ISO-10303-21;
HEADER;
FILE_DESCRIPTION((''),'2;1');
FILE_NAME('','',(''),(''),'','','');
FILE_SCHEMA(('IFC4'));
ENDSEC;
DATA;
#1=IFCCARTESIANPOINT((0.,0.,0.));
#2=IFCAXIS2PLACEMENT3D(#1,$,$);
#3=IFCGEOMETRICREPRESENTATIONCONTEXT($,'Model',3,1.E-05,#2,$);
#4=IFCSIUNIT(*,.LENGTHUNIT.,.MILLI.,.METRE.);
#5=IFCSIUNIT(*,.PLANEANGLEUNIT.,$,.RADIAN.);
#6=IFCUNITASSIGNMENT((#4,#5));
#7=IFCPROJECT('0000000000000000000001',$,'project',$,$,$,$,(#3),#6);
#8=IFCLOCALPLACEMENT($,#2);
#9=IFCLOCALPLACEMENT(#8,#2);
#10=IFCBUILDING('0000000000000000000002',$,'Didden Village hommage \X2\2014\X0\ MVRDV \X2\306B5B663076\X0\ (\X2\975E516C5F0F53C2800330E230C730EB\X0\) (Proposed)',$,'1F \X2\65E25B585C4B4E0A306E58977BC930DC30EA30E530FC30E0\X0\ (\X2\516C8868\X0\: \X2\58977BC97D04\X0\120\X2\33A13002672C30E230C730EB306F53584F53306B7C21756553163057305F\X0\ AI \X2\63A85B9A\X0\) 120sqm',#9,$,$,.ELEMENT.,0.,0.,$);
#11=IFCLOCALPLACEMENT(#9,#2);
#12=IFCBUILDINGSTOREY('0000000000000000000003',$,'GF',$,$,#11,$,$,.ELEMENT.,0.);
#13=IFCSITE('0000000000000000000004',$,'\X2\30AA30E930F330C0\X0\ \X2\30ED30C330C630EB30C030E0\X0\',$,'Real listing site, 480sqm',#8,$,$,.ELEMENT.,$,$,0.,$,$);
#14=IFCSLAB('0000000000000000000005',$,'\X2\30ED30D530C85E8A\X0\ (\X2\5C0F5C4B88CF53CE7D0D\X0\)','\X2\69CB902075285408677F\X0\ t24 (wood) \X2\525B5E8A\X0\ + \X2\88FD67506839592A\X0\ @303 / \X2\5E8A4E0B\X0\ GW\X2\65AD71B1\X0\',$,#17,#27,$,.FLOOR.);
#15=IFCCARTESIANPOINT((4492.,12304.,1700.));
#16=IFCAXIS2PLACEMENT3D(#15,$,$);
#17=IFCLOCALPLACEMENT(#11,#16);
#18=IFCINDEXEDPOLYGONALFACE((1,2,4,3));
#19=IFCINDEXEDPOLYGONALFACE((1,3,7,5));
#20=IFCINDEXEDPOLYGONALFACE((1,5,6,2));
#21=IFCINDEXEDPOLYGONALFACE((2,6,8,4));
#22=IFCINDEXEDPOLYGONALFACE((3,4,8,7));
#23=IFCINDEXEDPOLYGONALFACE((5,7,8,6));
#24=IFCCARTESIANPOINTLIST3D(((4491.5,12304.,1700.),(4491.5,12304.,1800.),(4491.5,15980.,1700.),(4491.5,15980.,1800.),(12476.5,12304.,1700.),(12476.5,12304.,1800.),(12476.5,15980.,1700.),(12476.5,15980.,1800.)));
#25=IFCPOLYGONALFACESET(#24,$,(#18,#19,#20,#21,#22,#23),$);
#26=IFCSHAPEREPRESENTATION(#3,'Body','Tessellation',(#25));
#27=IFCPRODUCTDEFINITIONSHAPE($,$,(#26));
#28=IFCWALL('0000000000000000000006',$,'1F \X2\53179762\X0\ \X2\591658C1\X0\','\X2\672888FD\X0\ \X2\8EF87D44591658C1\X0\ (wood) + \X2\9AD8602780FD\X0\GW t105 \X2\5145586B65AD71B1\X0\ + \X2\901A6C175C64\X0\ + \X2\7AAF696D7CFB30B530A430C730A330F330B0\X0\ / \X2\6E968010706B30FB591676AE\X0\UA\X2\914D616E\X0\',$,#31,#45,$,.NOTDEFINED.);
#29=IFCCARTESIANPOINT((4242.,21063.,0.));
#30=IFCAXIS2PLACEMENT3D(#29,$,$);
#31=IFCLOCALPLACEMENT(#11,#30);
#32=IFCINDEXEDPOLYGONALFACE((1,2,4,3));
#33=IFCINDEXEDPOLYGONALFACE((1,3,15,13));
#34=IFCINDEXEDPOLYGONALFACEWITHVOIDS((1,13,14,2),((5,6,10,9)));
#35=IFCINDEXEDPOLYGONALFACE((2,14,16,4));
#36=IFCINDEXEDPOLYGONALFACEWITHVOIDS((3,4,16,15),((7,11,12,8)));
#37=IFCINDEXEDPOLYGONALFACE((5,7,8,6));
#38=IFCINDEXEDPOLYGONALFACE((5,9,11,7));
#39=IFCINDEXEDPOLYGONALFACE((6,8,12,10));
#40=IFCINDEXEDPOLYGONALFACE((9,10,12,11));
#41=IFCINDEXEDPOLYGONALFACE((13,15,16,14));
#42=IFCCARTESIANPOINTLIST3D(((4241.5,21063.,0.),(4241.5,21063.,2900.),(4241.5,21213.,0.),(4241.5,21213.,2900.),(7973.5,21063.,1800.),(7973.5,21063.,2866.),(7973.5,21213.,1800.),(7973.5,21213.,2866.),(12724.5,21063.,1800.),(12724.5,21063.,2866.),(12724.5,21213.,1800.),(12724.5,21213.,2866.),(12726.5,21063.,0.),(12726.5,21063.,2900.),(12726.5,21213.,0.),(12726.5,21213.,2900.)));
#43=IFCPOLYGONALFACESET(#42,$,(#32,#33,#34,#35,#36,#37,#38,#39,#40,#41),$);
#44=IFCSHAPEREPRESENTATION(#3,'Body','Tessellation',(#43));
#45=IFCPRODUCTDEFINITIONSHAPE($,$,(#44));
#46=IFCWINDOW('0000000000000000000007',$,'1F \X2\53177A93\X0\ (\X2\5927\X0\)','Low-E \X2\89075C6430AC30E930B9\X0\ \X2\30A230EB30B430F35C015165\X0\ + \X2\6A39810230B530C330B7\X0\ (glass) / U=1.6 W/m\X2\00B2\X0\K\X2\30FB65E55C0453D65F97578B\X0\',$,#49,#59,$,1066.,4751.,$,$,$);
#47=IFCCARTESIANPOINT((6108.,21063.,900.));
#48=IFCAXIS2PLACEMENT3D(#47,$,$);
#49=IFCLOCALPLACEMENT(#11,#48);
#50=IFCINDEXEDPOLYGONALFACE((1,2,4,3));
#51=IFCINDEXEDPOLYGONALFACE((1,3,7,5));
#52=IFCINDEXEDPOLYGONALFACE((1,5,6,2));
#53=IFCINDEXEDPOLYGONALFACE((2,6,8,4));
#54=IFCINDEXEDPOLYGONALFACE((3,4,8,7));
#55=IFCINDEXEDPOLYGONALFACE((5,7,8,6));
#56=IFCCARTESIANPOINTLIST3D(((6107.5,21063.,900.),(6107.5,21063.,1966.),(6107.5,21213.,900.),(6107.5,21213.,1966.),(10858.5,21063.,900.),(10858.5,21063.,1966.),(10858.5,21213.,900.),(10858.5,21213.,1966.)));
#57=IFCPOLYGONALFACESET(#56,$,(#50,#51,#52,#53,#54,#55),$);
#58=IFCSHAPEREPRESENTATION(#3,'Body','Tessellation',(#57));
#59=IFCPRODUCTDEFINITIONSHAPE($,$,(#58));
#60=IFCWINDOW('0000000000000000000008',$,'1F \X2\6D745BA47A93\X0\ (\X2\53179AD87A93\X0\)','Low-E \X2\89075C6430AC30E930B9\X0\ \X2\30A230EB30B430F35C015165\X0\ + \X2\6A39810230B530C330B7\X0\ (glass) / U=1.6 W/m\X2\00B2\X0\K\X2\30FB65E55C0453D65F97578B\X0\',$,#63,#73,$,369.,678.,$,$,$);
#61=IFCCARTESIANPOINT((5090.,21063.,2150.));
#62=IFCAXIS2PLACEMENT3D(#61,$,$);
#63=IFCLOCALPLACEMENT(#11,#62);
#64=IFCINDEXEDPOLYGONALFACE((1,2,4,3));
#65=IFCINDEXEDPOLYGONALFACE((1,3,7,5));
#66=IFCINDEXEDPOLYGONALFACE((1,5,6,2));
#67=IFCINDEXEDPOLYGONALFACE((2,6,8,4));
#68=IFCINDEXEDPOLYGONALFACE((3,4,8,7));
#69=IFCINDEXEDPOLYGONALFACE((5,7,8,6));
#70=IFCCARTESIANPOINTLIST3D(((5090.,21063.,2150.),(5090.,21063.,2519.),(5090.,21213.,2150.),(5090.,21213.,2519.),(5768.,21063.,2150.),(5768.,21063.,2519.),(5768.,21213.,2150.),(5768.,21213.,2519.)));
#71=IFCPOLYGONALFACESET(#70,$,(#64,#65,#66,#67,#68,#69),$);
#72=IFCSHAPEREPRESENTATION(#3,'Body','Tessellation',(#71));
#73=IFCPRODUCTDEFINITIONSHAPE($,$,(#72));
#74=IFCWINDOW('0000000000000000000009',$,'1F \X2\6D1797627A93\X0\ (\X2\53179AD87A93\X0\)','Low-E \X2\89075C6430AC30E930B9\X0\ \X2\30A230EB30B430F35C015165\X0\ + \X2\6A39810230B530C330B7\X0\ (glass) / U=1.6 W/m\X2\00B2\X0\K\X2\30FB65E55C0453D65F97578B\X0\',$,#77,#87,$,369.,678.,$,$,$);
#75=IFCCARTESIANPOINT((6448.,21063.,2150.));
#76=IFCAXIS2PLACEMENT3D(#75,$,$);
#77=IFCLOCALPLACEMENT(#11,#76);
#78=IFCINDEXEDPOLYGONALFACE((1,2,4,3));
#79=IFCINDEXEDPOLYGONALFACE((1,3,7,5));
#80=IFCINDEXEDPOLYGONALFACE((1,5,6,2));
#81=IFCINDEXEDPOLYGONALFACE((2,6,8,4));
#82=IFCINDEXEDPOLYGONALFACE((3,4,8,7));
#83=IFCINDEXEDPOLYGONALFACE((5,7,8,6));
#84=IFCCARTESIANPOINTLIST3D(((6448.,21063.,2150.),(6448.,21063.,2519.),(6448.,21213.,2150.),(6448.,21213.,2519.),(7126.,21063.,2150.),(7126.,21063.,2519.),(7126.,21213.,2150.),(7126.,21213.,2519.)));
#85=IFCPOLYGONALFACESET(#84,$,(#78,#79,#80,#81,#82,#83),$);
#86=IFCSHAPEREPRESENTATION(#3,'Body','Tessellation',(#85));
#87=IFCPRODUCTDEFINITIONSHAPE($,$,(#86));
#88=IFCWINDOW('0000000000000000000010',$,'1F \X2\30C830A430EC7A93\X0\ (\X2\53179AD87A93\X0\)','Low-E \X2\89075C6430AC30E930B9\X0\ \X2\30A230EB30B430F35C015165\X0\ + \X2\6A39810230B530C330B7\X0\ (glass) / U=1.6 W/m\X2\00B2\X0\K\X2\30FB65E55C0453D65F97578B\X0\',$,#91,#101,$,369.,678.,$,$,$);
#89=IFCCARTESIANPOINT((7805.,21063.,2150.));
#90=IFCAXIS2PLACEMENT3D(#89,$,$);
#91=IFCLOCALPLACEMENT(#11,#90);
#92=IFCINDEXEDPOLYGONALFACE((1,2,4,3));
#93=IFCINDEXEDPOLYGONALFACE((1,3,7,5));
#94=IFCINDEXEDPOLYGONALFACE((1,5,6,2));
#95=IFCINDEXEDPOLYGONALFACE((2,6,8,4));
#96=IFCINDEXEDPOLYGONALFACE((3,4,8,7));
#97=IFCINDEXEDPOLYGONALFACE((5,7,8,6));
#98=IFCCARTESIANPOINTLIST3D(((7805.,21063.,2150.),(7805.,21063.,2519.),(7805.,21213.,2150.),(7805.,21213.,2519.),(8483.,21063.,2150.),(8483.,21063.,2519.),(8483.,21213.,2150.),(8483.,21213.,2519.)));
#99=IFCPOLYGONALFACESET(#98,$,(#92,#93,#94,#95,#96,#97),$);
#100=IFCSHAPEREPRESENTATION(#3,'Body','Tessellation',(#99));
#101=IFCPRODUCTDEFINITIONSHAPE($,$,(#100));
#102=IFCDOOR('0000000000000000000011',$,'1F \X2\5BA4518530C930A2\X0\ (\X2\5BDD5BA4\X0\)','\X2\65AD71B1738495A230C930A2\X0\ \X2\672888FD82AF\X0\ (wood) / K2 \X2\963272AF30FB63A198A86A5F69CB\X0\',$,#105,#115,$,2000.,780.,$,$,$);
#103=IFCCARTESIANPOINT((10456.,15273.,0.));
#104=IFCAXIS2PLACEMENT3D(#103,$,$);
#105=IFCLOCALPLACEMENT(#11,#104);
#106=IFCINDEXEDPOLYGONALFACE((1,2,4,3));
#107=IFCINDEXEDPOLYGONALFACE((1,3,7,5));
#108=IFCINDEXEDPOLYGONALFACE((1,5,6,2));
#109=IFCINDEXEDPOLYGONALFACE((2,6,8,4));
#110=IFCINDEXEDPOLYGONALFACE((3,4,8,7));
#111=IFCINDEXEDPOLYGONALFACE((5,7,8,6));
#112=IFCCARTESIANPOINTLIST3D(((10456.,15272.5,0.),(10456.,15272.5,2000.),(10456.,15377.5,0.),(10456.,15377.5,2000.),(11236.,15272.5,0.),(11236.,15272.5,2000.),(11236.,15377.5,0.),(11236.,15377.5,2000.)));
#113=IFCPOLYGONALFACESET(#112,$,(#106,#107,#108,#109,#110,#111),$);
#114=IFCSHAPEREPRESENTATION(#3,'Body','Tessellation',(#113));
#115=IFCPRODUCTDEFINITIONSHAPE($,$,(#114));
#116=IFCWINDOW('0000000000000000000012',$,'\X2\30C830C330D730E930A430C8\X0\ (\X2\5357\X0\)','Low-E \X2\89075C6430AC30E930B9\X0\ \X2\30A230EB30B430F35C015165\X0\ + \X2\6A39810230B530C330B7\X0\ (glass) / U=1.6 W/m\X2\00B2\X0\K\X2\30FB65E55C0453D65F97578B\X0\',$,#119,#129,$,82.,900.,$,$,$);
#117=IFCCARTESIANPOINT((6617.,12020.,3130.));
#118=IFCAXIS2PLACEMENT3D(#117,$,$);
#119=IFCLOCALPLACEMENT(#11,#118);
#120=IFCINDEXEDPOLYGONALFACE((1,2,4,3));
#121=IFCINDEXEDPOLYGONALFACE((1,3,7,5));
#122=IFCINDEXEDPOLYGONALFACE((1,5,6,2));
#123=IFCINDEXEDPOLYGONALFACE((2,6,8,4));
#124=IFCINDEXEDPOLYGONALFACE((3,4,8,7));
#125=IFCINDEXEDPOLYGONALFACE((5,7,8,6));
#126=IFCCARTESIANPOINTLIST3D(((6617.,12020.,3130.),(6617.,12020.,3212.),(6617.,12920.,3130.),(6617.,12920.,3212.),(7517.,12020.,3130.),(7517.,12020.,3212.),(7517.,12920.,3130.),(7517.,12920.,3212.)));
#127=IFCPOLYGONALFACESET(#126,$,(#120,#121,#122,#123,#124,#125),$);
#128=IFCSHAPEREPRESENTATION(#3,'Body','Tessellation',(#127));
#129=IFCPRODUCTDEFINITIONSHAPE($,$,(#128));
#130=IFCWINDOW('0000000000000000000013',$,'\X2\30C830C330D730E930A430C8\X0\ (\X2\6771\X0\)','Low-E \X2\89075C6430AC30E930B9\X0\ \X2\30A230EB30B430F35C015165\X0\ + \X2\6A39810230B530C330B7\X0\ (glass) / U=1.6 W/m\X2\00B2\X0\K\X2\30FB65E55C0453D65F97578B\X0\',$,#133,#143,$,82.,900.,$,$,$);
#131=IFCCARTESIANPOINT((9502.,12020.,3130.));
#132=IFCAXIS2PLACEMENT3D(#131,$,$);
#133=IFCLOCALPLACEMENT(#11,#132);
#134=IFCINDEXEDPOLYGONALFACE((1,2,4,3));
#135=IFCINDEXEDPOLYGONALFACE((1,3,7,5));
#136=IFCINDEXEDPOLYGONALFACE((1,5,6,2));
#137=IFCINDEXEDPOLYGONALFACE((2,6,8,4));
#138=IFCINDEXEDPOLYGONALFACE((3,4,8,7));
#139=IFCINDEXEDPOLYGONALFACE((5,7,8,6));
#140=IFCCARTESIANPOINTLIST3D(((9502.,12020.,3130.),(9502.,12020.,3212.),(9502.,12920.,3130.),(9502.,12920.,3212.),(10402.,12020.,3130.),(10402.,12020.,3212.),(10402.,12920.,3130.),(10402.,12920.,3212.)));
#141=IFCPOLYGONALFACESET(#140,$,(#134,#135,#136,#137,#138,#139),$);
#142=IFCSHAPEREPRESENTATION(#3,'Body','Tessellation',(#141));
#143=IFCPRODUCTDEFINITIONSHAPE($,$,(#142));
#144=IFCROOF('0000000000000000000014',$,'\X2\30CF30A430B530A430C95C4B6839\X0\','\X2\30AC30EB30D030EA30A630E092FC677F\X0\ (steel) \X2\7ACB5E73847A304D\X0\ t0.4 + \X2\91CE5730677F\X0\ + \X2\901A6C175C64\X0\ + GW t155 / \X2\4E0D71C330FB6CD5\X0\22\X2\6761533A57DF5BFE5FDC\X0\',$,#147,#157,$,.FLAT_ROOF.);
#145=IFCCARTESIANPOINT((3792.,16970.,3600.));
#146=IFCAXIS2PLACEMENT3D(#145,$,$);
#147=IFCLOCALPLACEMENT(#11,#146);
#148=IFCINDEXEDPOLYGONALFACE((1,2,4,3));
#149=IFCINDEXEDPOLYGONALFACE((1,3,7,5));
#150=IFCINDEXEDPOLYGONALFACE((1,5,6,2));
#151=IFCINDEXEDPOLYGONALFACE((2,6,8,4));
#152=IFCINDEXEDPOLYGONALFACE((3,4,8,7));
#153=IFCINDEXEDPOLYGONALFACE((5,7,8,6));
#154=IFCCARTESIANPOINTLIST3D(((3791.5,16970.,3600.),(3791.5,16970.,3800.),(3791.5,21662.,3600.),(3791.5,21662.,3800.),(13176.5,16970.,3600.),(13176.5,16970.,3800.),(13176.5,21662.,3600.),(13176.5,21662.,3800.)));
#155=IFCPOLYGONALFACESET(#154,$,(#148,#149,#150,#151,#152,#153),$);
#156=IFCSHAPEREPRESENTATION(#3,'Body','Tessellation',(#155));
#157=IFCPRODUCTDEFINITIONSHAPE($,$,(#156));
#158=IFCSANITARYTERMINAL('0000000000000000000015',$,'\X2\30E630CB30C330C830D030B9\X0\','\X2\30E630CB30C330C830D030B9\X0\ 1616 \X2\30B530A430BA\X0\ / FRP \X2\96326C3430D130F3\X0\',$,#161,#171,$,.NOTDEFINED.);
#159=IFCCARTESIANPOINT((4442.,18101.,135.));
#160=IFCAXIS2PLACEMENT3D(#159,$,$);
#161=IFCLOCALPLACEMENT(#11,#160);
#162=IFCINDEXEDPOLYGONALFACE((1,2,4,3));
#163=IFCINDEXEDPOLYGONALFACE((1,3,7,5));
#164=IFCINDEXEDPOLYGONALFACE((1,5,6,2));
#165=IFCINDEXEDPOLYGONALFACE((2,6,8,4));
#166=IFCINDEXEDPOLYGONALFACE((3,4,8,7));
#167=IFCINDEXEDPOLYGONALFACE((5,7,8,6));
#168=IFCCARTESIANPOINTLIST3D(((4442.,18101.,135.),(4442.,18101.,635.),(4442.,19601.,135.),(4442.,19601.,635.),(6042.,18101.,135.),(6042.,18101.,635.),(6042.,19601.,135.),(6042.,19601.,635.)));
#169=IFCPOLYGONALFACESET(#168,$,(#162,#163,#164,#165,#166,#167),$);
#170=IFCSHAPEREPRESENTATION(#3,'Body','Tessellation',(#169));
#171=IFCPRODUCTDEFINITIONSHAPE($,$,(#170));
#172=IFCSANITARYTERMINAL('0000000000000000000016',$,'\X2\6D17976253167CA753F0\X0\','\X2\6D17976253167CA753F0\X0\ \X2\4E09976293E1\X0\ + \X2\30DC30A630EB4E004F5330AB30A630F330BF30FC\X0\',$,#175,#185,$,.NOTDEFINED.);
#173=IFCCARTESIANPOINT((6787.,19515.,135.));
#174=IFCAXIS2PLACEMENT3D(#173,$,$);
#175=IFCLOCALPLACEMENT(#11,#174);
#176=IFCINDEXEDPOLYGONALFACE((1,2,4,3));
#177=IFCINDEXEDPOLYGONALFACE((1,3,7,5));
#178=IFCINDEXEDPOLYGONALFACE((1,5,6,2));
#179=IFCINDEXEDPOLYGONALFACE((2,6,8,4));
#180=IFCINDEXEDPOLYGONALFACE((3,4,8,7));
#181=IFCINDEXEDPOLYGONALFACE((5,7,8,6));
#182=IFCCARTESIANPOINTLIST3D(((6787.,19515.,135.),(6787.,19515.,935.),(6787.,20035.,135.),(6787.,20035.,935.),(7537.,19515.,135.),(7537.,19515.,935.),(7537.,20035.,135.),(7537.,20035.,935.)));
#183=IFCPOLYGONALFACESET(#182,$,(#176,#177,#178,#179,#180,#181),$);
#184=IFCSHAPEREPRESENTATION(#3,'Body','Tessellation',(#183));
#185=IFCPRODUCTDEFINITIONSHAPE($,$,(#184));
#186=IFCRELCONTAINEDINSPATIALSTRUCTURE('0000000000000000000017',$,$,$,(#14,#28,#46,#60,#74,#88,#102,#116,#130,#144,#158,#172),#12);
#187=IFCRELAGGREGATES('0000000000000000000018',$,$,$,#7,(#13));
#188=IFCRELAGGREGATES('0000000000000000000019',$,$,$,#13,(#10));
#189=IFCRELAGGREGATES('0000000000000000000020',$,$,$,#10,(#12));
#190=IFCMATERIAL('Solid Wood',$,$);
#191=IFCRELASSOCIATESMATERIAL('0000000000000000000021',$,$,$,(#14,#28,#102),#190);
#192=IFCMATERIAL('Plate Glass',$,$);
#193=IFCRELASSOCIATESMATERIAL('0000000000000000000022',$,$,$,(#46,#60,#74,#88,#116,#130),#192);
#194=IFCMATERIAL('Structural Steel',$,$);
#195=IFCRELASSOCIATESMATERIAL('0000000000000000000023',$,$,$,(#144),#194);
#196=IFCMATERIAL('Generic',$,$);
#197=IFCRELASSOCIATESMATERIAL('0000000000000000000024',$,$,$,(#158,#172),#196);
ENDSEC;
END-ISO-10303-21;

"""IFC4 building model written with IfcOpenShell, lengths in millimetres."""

from ifc_helpers import new_model, si_unit, frame, frame_2d, origin, place, context, project, spatial, rectangle, extrude, material, element, fill, save


model = new_model("IFC4")

# Units and contexts
model_context = context("Model", 3, precision=1e-05, world=origin())
ifc_project = project(units=[si_unit("LENGTHUNIT", "METRE", prefix="MILLI"), si_unit("PLANEANGLEUNIT", "RADIAN")], contexts=[model_context])

# Site, building, storey
site_placement = place(None, origin())
site = spatial("IfcSite", under=ifc_project, at=site_placement, Name="オランダ ロッテルダム", ObjectType="Real listing site, 480sqm", CompositionType="ELEMENT", RefElevation=0.0)
building_placement = place(site_placement, origin())
building = spatial("IfcBuilding", under=site, at=building_placement, Name="Didden Village hommage — MVRDV に学ぶ (非公式参考モデル) (Proposed)", ObjectType="1F 既存屋上の増築ボリューム (公表: 増築約120㎡。本モデルは単体に簡略化した AI 推定) 120sqm", CompositionType="ELEMENT", ElevationOfRefHeight=0.0, ElevationOfTerrain=0.0)
storey_placement = place(building_placement, origin())
storey = spatial("IfcBuildingStorey", under=building, at=storey_placement, Name="GF", CompositionType="ELEMENT", Elevation=0.0)

# Slab
ifc_material_1 = material(Name="Solid Wood")
slab_placement = place(storey_placement, frame((4492.0, 12304.0, 1700.0)))
element("IfcSlab", 1, at=slab_placement, inside=storey, material=ifc_material_1, Name="ロフト床 (小屋裏収納)", Description="構造用合板 t24 (wood) 剛床 + 製材根太 @303 / 床下 GW断熱", PredefinedType="FLOOR", context=model_context, shape_type="SweptSolid", body=[
    extrude(rectangle(XDim=7985.0, YDim=3676.0, at=frame_2d((3992.0, 1838.0))), frame((4492.0, 12304.0, 1700.0)), (0.0, 0.0, 1.0), 100.0),
])

# Wall, openings, windows
wall_1_placement = place(storey_placement, frame((4242.0, 21063.0, 0.0)))
wall_1 = element("IfcWall", 2, at=wall_1_placement, inside=storey, material=ifc_material_1, Name="1F 北面 外壁", Description="木製 軸組外壁 (wood) + 高性能GW t105 充填断熱 + 通気層 + 窯業系サイディング / 準耐火・外皮UA配慮", PredefinedType="NOTDEFINED", context=model_context, shape_type="SweptSolid", body=[
    extrude(rectangle(XDim=8485.0, YDim=150.0, at=frame_2d((4242.0, 75.0))), frame((4242.0, 21063.0, 0.0)), (0.0, 0.0, 1.0), 2900.0),
])
opening_1_placement = place(storey_placement, frame((6108.0, 21063.0, 900.0)))
opening_1 = element("IfcOpeningElement", 3, at=opening_1_placement, cuts=wall_1, PredefinedType="NOTDEFINED", context=model_context, shape_type="SweptSolid", body=[
    extrude(rectangle(XDim=4751.0, YDim=150.0, at=frame_2d((2375.0, 75.0))), frame((6108.0, 21063.0, 900.0)), (0.0, 0.0, 1.0), 1066.0),
])
opening_2_placement = place(storey_placement, frame((5090.0, 21063.0, 2150.0)))
opening_2 = element("IfcOpeningElement", 4, at=opening_2_placement, cuts=wall_1, PredefinedType="NOTDEFINED", context=model_context, shape_type="SweptSolid", body=[
    extrude(rectangle(XDim=678.0, YDim=150.0, at=frame_2d((339.0, 75.0))), frame((5090.0, 21063.0, 2150.0)), (0.0, 0.0, 1.0), 369.0),
])
opening_3_placement = place(storey_placement, frame((6448.0, 21063.0, 2150.0)))
opening_3 = element("IfcOpeningElement", 5, at=opening_3_placement, cuts=wall_1, PredefinedType="NOTDEFINED", context=model_context, shape_type="SweptSolid", body=[
    extrude(rectangle(XDim=678.0, YDim=150.0, at=frame_2d((339.0, 75.0))), frame((6448.0, 21063.0, 2150.0)), (0.0, 0.0, 1.0), 369.0),
])
opening_4_placement = place(storey_placement, frame((7805.0, 21063.0, 2150.0)))
opening_4 = element("IfcOpeningElement", 6, at=opening_4_placement, cuts=wall_1, PredefinedType="NOTDEFINED", context=model_context, shape_type="SweptSolid", body=[
    extrude(rectangle(XDim=678.0, YDim=150.0, at=frame_2d((339.0, 75.0))), frame((7805.0, 21063.0, 2150.0)), (0.0, 0.0, 1.0), 369.0),
])
ifc_material_2 = material(Name="Plate Glass")
window_1_placement = place(storey_placement, frame((6108.0, 21063.0, 900.0)))
window_1 = element("IfcWindow", 7, at=window_1_placement, inside=storey, material=ifc_material_2, Name="1F 北窓 (大)", Description="Low-E 複層ガラス アルゴン封入 + 樹脂サッシ (glass) / U=1.6 W/m²K・日射取得型", OverallHeight=1066.0, OverallWidth=4751.0, context=model_context, shape_type="SweptSolid", body=[
    extrude(rectangle(XDim=4751.0, YDim=150.0, at=frame_2d((2375.0, 75.0))), frame((6108.0, 21063.0, 900.0)), (0.0, 0.0, 1.0), 1066.0),
])
fill(opening_1, window_1)
window_2_placement = place(storey_placement, frame((5090.0, 21063.0, 2150.0)))
window_2 = element("IfcWindow", 8, at=window_2_placement, inside=storey, material=ifc_material_2, Name="1F 浴室窓 (北高窓)", Description="Low-E 複層ガラス アルゴン封入 + 樹脂サッシ (glass) / U=1.6 W/m²K・日射取得型", OverallHeight=369.0, OverallWidth=678.0, context=model_context, shape_type="SweptSolid", body=[
    extrude(rectangle(XDim=678.0, YDim=150.0, at=frame_2d((339.0, 75.0))), frame((5090.0, 21063.0, 2150.0)), (0.0, 0.0, 1.0), 369.0),
])
fill(opening_2, window_2)
window_3_placement = place(storey_placement, frame((6448.0, 21063.0, 2150.0)))
window_3 = element("IfcWindow", 9, at=window_3_placement, inside=storey, material=ifc_material_2, Name="1F 洗面窓 (北高窓)", Description="Low-E 複層ガラス アルゴン封入 + 樹脂サッシ (glass) / U=1.6 W/m²K・日射取得型", OverallHeight=369.0, OverallWidth=678.0, context=model_context, shape_type="SweptSolid", body=[
    extrude(rectangle(XDim=678.0, YDim=150.0, at=frame_2d((339.0, 75.0))), frame((6448.0, 21063.0, 2150.0)), (0.0, 0.0, 1.0), 369.0),
])
fill(opening_3, window_3)
window_4_placement = place(storey_placement, frame((7805.0, 21063.0, 2150.0)))
window_4 = element("IfcWindow", 10, at=window_4_placement, inside=storey, material=ifc_material_2, Name="1F トイレ窓 (北高窓)", Description="Low-E 複層ガラス アルゴン封入 + 樹脂サッシ (glass) / U=1.6 W/m²K・日射取得型", OverallHeight=369.0, OverallWidth=678.0, context=model_context, shape_type="SweptSolid", body=[
    extrude(rectangle(XDim=678.0, YDim=150.0, at=frame_2d((339.0, 75.0))), frame((7805.0, 21063.0, 2150.0)), (0.0, 0.0, 1.0), 369.0),
])
fill(opening_4, window_4)

# Door
door_1_placement = place(storey_placement, frame((10456.0, 15273.0, 0.0)))
element("IfcDoor", 11, at=door_1_placement, inside=storey, material=ifc_material_1, Name="1F 室内ドア (寝室)", Description="断熱玄関ドア 木製芯 (wood) / K2 防犯・採風機構", OverallHeight=2000.0, OverallWidth=780.0, context=model_context, shape_type="SweptSolid", body=[
    extrude(rectangle(XDim=780.0, YDim=105.0, at=frame_2d((390.0, 52.0))), frame((10456.0, 15273.0, 0.0)), (0.0, 0.0, 1.0), 2000.0),
])

# Windows
window_5_placement = place(storey_placement, frame((6617.0, 12020.0, 3130.0)))
element("IfcWindow", 12, at=window_5_placement, inside=storey, material=ifc_material_2, Name="トップライト (南)", Description="Low-E 複層ガラス アルゴン封入 + 樹脂サッシ (glass) / U=1.6 W/m²K・日射取得型", OverallHeight=82.0, OverallWidth=900.0, context=model_context, shape_type="SweptSolid", body=[
    extrude(rectangle(XDim=900.0, YDim=900.0, at=frame_2d((450.0, 450.0))), frame((6617.0, 12020.0, 3130.0)), (0.0, 0.0, 1.0), 82.0),
])
window_6_placement = place(storey_placement, frame((9502.0, 12020.0, 3130.0)))
element("IfcWindow", 13, at=window_6_placement, inside=storey, material=ifc_material_2, Name="トップライト (東)", Description="Low-E 複層ガラス アルゴン封入 + 樹脂サッシ (glass) / U=1.6 W/m²K・日射取得型", OverallHeight=82.0, OverallWidth=900.0, context=model_context, shape_type="SweptSolid", body=[
    extrude(rectangle(XDim=900.0, YDim=900.0, at=frame_2d((450.0, 450.0))), frame((9502.0, 12020.0, 3130.0)), (0.0, 0.0, 1.0), 82.0),
])

# Roof
ifc_material_3 = material(Name="Structural Steel")
roof_placement = place(storey_placement, frame((3792.0, 16970.0, 3600.0)))
element("IfcRoof", 14, at=roof_placement, inside=storey, material=ifc_material_3, Name="ハイサイド屋根", Description="ガルバリウム鋼板 (steel) 立平葺き t0.4 + 野地板 + 通気層 + GW t155 / 不燃・法22条区域対応", PredefinedType="FLAT_ROOF", context=model_context, shape_type="SweptSolid", body=[
    extrude(rectangle(XDim=9385.0, YDim=4692.0, at=frame_2d((4692.0, 2346.0))), frame((3792.0, 16970.0, 3600.0)), (0.0, 0.0, 1.0), 200.0),
])

# Sanitary terminals
ifc_material_4 = material(Name="Generic")
sanitary_terminal_1_placement = place(storey_placement, frame((4442.0, 18101.0, 135.0)))
element("IfcSanitaryTerminal", 15, at=sanitary_terminal_1_placement, inside=storey, material=ifc_material_4, Name="ユニットバス", Description="ユニットバス 1616 サイズ / FRP 防水パン", PredefinedType="NOTDEFINED", context=model_context, shape_type="SweptSolid", body=[
    extrude(rectangle(XDim=1600.0, YDim=1500.0, at=frame_2d((800.0, 750.0))), frame((4442.0, 18101.0, 135.0)), (0.0, 0.0, 1.0), 500.0),
])
sanitary_terminal_2_placement = place(storey_placement, frame((6787.0, 19515.0, 135.0)))
element("IfcSanitaryTerminal", 16, at=sanitary_terminal_2_placement, inside=storey, material=ifc_material_4, Name="洗面化粧台", Description="洗面化粧台 三面鏡 + ボウル一体カウンター", PredefinedType="NOTDEFINED", context=model_context, shape_type="SweptSolid", body=[
    extrude(rectangle(XDim=750.0, YDim=520.0, at=frame_2d((375.0, 260.0))), frame((6787.0, 19515.0, 135.0)), (0.0, 0.0, 1.0), 800.0),
])

save(model, "model.ifc")
